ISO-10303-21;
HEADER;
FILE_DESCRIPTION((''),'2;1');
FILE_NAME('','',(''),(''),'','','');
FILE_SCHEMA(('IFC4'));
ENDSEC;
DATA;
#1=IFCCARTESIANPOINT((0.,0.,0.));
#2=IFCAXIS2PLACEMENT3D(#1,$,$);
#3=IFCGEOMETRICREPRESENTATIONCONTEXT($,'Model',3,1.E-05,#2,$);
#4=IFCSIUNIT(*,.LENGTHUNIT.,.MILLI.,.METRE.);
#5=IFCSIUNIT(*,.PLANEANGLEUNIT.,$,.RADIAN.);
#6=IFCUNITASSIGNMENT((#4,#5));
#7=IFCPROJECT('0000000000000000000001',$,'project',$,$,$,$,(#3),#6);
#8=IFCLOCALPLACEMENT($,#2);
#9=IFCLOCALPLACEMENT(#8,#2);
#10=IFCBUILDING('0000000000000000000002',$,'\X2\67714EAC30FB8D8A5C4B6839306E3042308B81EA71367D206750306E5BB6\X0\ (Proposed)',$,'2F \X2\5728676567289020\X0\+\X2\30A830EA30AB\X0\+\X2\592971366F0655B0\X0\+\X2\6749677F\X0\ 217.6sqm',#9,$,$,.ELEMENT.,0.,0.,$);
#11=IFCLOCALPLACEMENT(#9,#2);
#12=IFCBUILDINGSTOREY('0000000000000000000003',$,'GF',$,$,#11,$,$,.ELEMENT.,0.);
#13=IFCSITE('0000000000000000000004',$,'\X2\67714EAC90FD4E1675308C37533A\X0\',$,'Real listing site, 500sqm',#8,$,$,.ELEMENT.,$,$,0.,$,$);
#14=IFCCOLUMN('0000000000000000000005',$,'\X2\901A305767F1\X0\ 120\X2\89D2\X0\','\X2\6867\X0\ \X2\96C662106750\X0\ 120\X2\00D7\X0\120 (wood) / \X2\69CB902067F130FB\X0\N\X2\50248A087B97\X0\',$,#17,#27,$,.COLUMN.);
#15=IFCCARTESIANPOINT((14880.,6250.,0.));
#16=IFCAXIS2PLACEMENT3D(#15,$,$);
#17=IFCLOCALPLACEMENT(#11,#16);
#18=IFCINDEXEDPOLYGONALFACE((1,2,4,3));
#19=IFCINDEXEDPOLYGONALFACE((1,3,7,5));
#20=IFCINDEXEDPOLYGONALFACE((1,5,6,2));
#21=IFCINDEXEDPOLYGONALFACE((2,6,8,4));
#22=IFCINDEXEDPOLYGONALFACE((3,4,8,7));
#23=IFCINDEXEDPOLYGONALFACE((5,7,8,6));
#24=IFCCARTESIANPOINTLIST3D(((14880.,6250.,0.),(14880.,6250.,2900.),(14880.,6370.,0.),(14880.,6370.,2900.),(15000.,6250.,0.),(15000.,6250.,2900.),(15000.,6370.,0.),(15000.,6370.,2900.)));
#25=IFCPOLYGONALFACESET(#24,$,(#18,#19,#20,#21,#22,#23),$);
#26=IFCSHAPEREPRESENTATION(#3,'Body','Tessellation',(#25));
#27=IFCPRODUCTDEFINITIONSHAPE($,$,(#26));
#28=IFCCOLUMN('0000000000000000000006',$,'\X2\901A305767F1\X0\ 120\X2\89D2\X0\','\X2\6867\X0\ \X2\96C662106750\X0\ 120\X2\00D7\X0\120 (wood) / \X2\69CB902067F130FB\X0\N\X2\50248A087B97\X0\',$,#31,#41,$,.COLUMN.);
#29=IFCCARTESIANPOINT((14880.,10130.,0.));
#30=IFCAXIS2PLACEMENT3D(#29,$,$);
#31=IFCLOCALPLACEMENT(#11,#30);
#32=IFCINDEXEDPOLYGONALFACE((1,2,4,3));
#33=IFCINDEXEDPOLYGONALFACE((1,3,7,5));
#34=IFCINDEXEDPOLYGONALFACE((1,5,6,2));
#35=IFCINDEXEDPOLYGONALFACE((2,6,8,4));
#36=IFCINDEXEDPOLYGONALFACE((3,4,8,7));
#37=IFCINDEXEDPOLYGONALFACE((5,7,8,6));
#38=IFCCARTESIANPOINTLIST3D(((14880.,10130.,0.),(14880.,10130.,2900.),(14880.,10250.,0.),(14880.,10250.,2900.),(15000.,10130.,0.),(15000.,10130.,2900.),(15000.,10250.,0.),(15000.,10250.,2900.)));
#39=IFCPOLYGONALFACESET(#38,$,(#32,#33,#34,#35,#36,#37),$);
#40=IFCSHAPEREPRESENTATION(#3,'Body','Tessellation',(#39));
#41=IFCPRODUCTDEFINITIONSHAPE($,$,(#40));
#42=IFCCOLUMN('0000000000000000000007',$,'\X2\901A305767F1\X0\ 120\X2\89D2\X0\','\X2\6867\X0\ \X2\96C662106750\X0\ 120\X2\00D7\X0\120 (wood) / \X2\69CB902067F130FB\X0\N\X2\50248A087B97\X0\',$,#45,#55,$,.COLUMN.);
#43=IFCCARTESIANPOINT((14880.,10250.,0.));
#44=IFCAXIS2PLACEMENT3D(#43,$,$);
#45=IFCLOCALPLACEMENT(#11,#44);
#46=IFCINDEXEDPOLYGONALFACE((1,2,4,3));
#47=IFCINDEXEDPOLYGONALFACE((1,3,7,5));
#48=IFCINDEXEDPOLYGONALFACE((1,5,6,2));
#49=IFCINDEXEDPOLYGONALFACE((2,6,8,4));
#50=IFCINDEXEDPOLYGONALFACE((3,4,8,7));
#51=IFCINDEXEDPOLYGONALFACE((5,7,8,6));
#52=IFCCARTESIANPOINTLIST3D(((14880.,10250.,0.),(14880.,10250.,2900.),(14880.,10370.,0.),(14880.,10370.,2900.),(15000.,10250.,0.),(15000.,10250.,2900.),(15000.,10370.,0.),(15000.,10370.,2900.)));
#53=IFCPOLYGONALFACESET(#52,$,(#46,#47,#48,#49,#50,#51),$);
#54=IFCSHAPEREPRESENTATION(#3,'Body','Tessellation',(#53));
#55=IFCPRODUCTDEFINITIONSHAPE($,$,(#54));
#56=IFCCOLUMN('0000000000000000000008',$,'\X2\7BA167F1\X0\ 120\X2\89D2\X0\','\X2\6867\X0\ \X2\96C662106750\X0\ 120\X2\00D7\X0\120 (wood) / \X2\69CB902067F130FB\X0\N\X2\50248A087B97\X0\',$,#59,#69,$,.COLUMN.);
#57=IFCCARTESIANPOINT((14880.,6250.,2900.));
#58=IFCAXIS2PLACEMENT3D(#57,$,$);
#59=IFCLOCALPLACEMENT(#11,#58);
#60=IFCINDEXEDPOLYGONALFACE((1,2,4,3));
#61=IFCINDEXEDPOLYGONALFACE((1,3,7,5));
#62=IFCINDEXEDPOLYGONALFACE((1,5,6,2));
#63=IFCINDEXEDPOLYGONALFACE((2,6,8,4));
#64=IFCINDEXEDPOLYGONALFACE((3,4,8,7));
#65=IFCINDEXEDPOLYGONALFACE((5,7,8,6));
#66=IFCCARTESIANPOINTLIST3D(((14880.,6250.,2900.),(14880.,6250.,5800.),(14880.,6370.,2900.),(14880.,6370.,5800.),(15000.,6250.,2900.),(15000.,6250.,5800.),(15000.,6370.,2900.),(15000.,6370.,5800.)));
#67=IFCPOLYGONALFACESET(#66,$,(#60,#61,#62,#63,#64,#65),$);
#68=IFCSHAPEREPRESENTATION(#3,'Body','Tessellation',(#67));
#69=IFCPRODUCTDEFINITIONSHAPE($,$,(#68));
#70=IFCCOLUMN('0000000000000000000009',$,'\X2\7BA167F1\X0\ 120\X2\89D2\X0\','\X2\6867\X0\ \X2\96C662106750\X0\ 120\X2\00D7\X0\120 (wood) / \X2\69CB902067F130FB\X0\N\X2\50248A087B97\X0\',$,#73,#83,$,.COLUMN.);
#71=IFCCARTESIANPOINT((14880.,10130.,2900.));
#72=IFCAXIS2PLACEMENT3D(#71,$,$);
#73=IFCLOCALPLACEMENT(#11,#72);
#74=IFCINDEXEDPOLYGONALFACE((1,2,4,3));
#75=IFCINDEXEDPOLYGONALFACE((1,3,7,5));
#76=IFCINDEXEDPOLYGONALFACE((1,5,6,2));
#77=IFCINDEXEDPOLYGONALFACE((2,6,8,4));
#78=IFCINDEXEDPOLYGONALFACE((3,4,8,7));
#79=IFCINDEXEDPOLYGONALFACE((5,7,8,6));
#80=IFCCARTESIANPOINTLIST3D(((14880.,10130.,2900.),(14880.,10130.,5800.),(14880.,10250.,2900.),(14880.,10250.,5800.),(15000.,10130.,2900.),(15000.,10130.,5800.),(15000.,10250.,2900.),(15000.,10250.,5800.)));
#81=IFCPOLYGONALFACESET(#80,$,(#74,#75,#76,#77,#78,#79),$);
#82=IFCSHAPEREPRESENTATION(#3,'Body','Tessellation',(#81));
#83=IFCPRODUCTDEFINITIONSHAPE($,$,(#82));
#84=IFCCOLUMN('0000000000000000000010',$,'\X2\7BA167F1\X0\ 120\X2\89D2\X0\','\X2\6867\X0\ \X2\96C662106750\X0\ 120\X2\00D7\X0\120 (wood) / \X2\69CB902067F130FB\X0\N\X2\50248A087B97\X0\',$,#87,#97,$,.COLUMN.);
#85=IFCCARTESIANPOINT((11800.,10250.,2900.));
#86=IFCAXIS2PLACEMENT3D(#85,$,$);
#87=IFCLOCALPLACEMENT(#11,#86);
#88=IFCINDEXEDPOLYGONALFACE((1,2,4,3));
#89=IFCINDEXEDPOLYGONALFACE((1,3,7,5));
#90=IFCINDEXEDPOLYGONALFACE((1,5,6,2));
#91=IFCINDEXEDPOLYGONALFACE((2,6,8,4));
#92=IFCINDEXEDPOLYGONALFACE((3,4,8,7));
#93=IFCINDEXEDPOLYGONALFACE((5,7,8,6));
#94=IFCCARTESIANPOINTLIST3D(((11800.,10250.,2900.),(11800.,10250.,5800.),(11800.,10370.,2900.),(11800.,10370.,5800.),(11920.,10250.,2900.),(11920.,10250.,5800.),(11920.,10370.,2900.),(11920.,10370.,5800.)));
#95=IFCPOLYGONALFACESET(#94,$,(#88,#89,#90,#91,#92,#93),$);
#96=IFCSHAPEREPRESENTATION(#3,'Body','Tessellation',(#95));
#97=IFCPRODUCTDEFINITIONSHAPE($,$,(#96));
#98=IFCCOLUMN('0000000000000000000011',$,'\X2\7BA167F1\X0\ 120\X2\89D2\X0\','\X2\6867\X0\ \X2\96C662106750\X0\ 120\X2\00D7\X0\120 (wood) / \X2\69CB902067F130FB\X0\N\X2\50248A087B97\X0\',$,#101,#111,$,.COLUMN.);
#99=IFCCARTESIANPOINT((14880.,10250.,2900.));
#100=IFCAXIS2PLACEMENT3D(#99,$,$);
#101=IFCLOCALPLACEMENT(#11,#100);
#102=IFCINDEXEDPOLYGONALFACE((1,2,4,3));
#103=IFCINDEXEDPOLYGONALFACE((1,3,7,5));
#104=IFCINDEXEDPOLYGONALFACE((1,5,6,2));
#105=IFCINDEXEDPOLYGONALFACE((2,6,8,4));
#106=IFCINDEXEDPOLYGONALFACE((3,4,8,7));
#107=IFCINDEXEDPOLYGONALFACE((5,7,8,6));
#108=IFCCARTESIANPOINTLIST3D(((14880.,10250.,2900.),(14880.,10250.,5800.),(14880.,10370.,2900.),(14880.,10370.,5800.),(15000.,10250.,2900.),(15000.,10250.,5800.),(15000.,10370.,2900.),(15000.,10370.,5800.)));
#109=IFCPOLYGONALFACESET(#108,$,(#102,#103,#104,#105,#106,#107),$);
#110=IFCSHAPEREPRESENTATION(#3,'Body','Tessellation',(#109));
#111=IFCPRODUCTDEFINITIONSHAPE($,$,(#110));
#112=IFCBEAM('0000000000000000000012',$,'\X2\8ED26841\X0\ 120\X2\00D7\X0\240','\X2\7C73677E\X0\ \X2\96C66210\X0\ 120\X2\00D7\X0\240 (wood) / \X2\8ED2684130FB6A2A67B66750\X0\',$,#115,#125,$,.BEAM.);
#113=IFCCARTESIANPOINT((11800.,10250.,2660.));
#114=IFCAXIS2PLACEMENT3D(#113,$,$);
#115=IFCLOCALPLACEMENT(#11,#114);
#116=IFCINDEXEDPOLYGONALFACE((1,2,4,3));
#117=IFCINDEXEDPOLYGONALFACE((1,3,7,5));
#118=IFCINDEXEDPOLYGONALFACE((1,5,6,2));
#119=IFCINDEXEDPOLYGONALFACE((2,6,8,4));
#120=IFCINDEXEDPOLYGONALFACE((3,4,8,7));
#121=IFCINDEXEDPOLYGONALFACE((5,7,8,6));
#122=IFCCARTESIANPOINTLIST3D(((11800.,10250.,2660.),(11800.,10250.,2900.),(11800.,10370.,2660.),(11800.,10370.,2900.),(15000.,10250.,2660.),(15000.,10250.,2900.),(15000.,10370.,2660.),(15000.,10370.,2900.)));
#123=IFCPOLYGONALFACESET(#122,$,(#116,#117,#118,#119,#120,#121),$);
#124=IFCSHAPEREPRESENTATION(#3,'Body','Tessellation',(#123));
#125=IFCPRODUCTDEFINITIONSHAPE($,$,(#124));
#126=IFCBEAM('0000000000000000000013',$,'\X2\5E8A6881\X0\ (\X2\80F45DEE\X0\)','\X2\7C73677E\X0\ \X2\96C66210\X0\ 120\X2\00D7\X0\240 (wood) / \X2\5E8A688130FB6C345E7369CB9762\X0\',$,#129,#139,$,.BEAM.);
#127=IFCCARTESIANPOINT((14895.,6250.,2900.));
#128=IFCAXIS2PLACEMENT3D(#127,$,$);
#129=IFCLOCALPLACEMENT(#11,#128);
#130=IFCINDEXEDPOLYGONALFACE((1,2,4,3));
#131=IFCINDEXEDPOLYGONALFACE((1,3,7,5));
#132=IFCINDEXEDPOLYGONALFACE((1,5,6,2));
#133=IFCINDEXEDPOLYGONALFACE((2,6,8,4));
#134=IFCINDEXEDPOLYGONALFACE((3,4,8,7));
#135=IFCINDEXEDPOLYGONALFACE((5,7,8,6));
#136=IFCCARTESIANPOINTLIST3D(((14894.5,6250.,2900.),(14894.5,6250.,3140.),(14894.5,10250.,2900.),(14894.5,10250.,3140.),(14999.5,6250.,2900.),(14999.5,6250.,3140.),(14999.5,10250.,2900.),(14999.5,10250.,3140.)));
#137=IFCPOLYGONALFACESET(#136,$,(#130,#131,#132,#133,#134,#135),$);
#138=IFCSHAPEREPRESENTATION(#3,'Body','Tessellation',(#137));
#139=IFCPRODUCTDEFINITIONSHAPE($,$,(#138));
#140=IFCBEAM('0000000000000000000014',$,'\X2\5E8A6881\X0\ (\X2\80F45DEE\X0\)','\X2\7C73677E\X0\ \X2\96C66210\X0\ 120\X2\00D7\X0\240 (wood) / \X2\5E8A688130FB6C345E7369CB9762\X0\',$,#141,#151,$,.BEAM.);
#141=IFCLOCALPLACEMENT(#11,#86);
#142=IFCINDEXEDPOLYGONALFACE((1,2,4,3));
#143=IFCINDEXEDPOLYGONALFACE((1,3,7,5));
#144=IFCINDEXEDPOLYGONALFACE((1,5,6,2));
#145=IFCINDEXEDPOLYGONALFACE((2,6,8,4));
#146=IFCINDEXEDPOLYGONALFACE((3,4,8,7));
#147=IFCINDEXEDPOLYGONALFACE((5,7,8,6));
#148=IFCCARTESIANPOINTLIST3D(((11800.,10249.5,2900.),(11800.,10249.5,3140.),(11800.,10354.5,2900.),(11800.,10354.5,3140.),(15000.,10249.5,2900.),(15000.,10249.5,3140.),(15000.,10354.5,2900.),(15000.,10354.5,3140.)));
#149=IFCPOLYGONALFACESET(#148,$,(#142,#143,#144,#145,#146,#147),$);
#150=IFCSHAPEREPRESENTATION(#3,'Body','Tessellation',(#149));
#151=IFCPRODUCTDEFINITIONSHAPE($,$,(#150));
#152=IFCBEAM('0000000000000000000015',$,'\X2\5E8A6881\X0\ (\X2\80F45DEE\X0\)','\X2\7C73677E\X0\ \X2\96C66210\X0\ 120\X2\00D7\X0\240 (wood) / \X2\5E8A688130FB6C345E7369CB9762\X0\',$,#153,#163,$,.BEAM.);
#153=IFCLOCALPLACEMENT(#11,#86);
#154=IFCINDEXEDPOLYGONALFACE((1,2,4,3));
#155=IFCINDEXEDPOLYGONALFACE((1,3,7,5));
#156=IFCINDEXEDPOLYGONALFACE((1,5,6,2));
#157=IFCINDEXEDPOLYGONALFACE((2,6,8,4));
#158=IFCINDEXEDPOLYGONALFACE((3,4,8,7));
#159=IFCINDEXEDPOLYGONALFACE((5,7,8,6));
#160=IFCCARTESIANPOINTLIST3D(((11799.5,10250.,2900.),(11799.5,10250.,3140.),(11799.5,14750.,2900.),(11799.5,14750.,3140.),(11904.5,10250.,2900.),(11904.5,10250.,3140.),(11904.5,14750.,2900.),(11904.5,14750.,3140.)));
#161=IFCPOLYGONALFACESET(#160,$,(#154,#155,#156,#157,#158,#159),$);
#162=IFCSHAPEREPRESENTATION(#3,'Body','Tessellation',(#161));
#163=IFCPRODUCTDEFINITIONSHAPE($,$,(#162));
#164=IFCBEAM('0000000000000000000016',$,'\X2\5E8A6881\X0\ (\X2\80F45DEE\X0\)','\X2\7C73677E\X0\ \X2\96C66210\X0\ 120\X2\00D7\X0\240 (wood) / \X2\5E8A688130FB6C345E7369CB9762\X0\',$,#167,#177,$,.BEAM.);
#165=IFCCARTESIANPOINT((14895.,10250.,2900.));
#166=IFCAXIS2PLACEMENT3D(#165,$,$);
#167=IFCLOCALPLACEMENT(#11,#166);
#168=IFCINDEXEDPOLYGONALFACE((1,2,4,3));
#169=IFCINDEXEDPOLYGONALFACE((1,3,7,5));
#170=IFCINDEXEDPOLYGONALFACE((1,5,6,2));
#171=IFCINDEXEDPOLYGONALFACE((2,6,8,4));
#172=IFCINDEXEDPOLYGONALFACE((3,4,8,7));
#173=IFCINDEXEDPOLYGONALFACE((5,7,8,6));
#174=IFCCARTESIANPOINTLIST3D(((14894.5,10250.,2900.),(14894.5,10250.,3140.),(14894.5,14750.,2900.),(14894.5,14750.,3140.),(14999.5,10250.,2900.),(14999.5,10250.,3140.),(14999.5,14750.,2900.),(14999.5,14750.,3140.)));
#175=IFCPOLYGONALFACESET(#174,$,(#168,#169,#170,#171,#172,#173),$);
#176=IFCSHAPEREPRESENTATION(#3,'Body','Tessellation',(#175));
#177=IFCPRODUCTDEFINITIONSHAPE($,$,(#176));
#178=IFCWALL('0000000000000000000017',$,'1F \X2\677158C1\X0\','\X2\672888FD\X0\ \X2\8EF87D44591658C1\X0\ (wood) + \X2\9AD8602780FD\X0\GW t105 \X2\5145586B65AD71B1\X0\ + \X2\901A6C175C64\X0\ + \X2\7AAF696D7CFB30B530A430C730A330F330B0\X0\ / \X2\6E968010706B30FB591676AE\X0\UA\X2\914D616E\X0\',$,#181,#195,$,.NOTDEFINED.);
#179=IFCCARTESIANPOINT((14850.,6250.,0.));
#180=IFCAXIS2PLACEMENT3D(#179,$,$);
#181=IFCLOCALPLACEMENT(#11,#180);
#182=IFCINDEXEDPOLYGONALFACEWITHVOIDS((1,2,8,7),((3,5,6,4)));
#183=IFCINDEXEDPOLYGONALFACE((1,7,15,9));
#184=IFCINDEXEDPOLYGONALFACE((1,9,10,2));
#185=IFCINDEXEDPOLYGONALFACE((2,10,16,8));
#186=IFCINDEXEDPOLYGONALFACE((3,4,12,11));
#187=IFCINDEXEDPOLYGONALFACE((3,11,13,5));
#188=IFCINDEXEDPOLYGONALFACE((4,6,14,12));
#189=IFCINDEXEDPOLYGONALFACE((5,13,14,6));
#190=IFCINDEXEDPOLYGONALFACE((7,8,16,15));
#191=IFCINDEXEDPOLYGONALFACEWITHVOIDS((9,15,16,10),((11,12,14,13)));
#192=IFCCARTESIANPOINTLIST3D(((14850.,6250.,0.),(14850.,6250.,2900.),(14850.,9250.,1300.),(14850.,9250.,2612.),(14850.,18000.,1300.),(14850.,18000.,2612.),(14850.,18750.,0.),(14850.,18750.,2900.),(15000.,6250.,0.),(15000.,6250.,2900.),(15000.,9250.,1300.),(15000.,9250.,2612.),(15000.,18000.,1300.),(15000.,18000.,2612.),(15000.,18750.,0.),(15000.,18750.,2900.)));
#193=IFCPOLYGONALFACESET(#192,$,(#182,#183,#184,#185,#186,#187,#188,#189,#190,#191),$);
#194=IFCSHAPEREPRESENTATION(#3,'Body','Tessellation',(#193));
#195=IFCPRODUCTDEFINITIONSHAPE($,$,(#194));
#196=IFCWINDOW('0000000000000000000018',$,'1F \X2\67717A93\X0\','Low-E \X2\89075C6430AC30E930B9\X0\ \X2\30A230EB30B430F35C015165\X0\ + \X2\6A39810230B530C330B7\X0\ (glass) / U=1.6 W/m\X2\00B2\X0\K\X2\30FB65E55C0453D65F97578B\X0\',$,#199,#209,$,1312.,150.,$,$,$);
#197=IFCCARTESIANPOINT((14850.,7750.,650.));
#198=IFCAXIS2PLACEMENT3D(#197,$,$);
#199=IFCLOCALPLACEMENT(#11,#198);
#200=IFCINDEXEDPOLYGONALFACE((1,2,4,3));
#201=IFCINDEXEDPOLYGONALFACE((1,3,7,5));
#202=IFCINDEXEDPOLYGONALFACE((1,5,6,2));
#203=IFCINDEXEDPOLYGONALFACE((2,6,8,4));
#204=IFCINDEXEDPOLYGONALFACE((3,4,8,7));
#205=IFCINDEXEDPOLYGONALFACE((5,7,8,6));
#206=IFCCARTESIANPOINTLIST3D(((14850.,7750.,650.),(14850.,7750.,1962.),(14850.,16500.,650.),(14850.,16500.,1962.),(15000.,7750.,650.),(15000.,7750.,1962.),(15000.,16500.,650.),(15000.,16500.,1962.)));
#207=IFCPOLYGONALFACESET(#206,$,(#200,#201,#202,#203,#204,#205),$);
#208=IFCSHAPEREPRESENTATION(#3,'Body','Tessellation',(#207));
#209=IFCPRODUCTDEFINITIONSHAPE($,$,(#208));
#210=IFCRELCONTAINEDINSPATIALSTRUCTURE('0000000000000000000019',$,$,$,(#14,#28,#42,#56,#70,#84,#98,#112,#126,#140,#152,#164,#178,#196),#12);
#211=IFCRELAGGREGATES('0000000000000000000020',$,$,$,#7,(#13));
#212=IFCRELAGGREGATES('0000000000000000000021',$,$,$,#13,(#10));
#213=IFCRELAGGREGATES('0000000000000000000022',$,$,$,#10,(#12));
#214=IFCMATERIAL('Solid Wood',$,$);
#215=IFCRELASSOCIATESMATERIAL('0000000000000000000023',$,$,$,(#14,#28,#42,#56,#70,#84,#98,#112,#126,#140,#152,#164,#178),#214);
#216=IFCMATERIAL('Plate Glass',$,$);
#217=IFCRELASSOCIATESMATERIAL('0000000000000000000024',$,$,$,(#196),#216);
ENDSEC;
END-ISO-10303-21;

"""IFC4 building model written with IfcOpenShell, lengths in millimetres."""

from ifc_helpers import new_model, si_unit, frame, frame_2d, origin, place, context, project, spatial, rectangle, extrude, material, element, fill, save


model = new_model("IFC4")

# Units and contexts
model_context = context("Model", 3, precision=1e-05, world=origin())
ifc_project = project(units=[si_unit("LENGTHUNIT", "METRE", prefix="MILLI"), si_unit("PLANEANGLEUNIT", "RADIAN")], contexts=[model_context])

# Site, building, storey
site_placement = place(None, origin())
site = spatial("IfcSite", under=ifc_project, at=site_placement, Name="東京都世田谷区", ObjectType="Real listing site, 500sqm", CompositionType="ELEMENT", RefElevation=0.0)
building_placement = place(site_placement, origin())
building = spatial("IfcBuilding", under=site, at=building_placement, Name="東京・越屋根のある自然素材の家 (Proposed)", ObjectType="2F 在来木造+エリカ+天然漆喰+杉板 217.6sqm", CompositionType="ELEMENT", ElevationOfRefHeight=0.0, ElevationOfTerrain=0.0)
storey_placement = place(building_placement, origin())
storey = spatial("IfcBuildingStorey", under=building, at=storey_placement, Name="GF", CompositionType="ELEMENT", Elevation=0.0)

# Columns
ifc_material_1 = material(Name="Solid Wood")
column_1_placement = place(storey_placement, frame((14880.0, 6250.0, 0.0)))
element("IfcColumn", 1, at=column_1_placement, inside=storey, material=ifc_material_1, Name="通し柱 120角", Description="桧 集成材 120×120 (wood) / 構造柱・N値計算", PredefinedType="COLUMN", context=model_context, shape_type="SweptSolid", body=[
    extrude(rectangle(XDim=120.0, YDim=120.0, at=frame_2d((60.0, 60.0))), frame((14880.0, 6250.0, 0.0)), (0.0, 0.0, 1.0), 2900.0),
])
column_2_placement = place(storey_placement, frame((14880.0, 10130.0, 0.0)))
element("IfcColumn", 2, at=column_2_placement, inside=storey, material=ifc_material_1, Name="通し柱 120角", Description="桧 集成材 120×120 (wood) / 構造柱・N値計算", PredefinedType="COLUMN", context=model_context, shape_type="SweptSolid", body=[
    extrude(rectangle(XDim=120.0, YDim=120.0, at=frame_2d((60.0, 60.0))), frame((14880.0, 10130.0, 0.0)), (0.0, 0.0, 1.0), 2900.0),
])
column_3_placement = place(storey_placement, frame((14880.0, 10250.0, 0.0)))
element("IfcColumn", 3, at=column_3_placement, inside=storey, material=ifc_material_1, Name="通し柱 120角", Description="桧 集成材 120×120 (wood) / 構造柱・N値計算", PredefinedType="COLUMN", context=model_context, shape_type="SweptSolid", body=[
    extrude(rectangle(XDim=120.0, YDim=120.0, at=frame_2d((60.0, 60.0))), frame((14880.0, 10250.0, 0.0)), (0.0, 0.0, 1.0), 2900.0),
])
column_4_placement = place(storey_placement, frame((14880.0, 6250.0, 2900.0)))
element("IfcColumn", 4, at=column_4_placement, inside=storey, material=ifc_material_1, Name="管柱 120角", Description="桧 集成材 120×120 (wood) / 構造柱・N値計算", PredefinedType="COLUMN", context=model_context, shape_type="SweptSolid", body=[
    extrude(rectangle(XDim=120.0, YDim=120.0, at=frame_2d((60.0, 60.0))), frame((14880.0, 6250.0, 2900.0)), (0.0, 0.0, 1.0), 2900.0),
])
column_5_placement = place(storey_placement, frame((14880.0, 10130.0, 2900.0)))
element("IfcColumn", 5, at=column_5_placement, inside=storey, material=ifc_material_1, Name="管柱 120角", Description="桧 集成材 120×120 (wood) / 構造柱・N値計算", PredefinedType="COLUMN", context=model_context, shape_type="SweptSolid", body=[
    extrude(rectangle(XDim=120.0, YDim=120.0, at=frame_2d((60.0, 60.0))), frame((14880.0, 10130.0, 2900.0)), (0.0, 0.0, 1.0), 2900.0),
])
column_6_placement = place(storey_placement, frame((11800.0, 10250.0, 2900.0)))
element("IfcColumn", 6, at=column_6_placement, inside=storey, material=ifc_material_1, Name="管柱 120角", Description="桧 集成材 120×120 (wood) / 構造柱・N値計算", PredefinedType="COLUMN", context=model_context, shape_type="SweptSolid", body=[
    extrude(rectangle(XDim=120.0, YDim=120.0, at=frame_2d((60.0, 60.0))), frame((11800.0, 10250.0, 2900.0)), (0.0, 0.0, 1.0), 2900.0),
])
column_7_placement = place(storey_placement, frame((14880.0, 10250.0, 2900.0)))
element("IfcColumn", 7, at=column_7_placement, inside=storey, material=ifc_material_1, Name="管柱 120角", Description="桧 集成材 120×120 (wood) / 構造柱・N値計算", PredefinedType="COLUMN", context=model_context, shape_type="SweptSolid", body=[
    extrude(rectangle(XDim=120.0, YDim=120.0, at=frame_2d((60.0, 60.0))), frame((14880.0, 10250.0, 2900.0)), (0.0, 0.0, 1.0), 2900.0),
])

# Beams
beam_1_placement = place(storey_placement, frame((11800.0, 10250.0, 2660.0)))
element("IfcBeam", 8, at=beam_1_placement, inside=storey, material=ifc_material_1, Name="軒桁 120×240", Description="米松 集成 120×240 (wood) / 軒桁・横架材", PredefinedType="BEAM", context=model_context, shape_type="SweptSolid", body=[
    extrude(rectangle(XDim=3200.0, YDim=120.0, at=frame_2d((1600.0, 60.0))), frame((11800.0, 10250.0, 2660.0)), (0.0, 0.0, 1.0), 240.0),
])
beam_2_placement = place(storey_placement, frame((14895.0, 6250.0, 2900.0)))
element("IfcBeam", 9, at=beam_2_placement, inside=storey, material=ifc_material_1, Name="床梁 (胴差)", Description="米松 集成 120×240 (wood) / 床梁・水平構面", PredefinedType="BEAM", context=model_context, shape_type="SweptSolid", body=[
    extrude(rectangle(XDim=105.0, YDim=4000.0, at=frame_2d((52.0, 2000.0))), frame((14895.0, 6250.0, 2900.0)), (0.0, 0.0, 1.0), 240.0),
])
beam_3_placement = place(storey_placement, frame((11800.0, 10250.0, 2900.0)))
element("IfcBeam", 10, at=beam_3_placement, inside=storey, material=ifc_material_1, Name="床梁 (胴差)", Description="米松 集成 120×240 (wood) / 床梁・水平構面", PredefinedType="BEAM", context=model_context, shape_type="SweptSolid", body=[
    extrude(rectangle(XDim=3200.0, YDim=105.0, at=frame_2d((1600.0, 52.0))), frame((11800.0, 10250.0, 2900.0)), (0.0, 0.0, 1.0), 240.0),
])
beam_4_placement = place(storey_placement, frame((11800.0, 10250.0, 2900.0)))
element("IfcBeam", 11, at=beam_4_placement, inside=storey, material=ifc_material_1, Name="床梁 (胴差)", Description="米松 集成 120×240 (wood) / 床梁・水平構面", PredefinedType="BEAM", context=model_context, shape_type="SweptSolid", body=[
    extrude(rectangle(XDim=105.0, YDim=4500.0, at=frame_2d((52.0, 2250.0))), frame((11800.0, 10250.0, 2900.0)), (0.0, 0.0, 1.0), 240.0),
])
beam_5_placement = place(storey_placement, frame((14895.0, 10250.0, 2900.0)))
element("IfcBeam", 12, at=beam_5_placement, inside=storey, material=ifc_material_1, Name="床梁 (胴差)", Description="米松 集成 120×240 (wood) / 床梁・水平構面", PredefinedType="BEAM", context=model_context, shape_type="SweptSolid", body=[
    extrude(rectangle(XDim=105.0, YDim=4500.0, at=frame_2d((52.0, 2250.0))), frame((14895.0, 10250.0, 2900.0)), (0.0, 0.0, 1.0), 240.0),
])

# Wall, opening, window
wall_1_placement = place(storey_placement, frame((14850.0, 6250.0, 0.0)))
wall_1 = element("IfcWall", 13, at=wall_1_placement, inside=storey, material=ifc_material_1, Name="1F 東壁", Description="木製 軸組外壁 (wood) + 高性能GW t105 充填断熱 + 通気層 + 窯業系サイディング / 準耐火・外皮UA配慮", PredefinedType="NOTDEFINED", context=model_context, shape_type="SweptSolid", body=[
    extrude(rectangle(XDim=150.0, YDim=12500.0, at=frame_2d((75.0, 6250.0))), frame((14850.0, 6250.0, 0.0)), (0.0, 0.0, 1.0), 2900.0),
])
opening_1_placement = place(storey_placement, frame((14850.0, 7750.0, 650.0)))
opening_1 = element("IfcOpeningElement", 14, at=opening_1_placement, cuts=wall_1, PredefinedType="NOTDEFINED", context=model_context, shape_type="SweptSolid", body=[
    extrude(rectangle(XDim=150.0, YDim=8750.0, at=frame_2d((75.0, 4375.0))), frame((14850.0, 7750.0, 650.0)), (0.0, 0.0, 1.0), 1312.0),
])
ifc_material_2 = material(Name="Plate Glass")
window_1_placement = place(storey_placement, frame((14850.0, 7750.0, 650.0)))
window_1 = element("IfcWindow", 15, at=window_1_placement, inside=storey, material=ifc_material_2, Name="1F 東窓", Description="Low-E 複層ガラス アルゴン封入 + 樹脂サッシ (glass) / U=1.6 W/m²K・日射取得型", OverallHeight=1312.0, OverallWidth=150.0, context=model_context, shape_type="SweptSolid", body=[
    extrude(rectangle(XDim=150.0, YDim=8750.0, at=frame_2d((75.0, 4375.0))), frame((14850.0, 7750.0, 650.0)), (0.0, 0.0, 1.0), 1312.0),
])
fill(opening_1, window_1)

save(model, "model.ifc")
